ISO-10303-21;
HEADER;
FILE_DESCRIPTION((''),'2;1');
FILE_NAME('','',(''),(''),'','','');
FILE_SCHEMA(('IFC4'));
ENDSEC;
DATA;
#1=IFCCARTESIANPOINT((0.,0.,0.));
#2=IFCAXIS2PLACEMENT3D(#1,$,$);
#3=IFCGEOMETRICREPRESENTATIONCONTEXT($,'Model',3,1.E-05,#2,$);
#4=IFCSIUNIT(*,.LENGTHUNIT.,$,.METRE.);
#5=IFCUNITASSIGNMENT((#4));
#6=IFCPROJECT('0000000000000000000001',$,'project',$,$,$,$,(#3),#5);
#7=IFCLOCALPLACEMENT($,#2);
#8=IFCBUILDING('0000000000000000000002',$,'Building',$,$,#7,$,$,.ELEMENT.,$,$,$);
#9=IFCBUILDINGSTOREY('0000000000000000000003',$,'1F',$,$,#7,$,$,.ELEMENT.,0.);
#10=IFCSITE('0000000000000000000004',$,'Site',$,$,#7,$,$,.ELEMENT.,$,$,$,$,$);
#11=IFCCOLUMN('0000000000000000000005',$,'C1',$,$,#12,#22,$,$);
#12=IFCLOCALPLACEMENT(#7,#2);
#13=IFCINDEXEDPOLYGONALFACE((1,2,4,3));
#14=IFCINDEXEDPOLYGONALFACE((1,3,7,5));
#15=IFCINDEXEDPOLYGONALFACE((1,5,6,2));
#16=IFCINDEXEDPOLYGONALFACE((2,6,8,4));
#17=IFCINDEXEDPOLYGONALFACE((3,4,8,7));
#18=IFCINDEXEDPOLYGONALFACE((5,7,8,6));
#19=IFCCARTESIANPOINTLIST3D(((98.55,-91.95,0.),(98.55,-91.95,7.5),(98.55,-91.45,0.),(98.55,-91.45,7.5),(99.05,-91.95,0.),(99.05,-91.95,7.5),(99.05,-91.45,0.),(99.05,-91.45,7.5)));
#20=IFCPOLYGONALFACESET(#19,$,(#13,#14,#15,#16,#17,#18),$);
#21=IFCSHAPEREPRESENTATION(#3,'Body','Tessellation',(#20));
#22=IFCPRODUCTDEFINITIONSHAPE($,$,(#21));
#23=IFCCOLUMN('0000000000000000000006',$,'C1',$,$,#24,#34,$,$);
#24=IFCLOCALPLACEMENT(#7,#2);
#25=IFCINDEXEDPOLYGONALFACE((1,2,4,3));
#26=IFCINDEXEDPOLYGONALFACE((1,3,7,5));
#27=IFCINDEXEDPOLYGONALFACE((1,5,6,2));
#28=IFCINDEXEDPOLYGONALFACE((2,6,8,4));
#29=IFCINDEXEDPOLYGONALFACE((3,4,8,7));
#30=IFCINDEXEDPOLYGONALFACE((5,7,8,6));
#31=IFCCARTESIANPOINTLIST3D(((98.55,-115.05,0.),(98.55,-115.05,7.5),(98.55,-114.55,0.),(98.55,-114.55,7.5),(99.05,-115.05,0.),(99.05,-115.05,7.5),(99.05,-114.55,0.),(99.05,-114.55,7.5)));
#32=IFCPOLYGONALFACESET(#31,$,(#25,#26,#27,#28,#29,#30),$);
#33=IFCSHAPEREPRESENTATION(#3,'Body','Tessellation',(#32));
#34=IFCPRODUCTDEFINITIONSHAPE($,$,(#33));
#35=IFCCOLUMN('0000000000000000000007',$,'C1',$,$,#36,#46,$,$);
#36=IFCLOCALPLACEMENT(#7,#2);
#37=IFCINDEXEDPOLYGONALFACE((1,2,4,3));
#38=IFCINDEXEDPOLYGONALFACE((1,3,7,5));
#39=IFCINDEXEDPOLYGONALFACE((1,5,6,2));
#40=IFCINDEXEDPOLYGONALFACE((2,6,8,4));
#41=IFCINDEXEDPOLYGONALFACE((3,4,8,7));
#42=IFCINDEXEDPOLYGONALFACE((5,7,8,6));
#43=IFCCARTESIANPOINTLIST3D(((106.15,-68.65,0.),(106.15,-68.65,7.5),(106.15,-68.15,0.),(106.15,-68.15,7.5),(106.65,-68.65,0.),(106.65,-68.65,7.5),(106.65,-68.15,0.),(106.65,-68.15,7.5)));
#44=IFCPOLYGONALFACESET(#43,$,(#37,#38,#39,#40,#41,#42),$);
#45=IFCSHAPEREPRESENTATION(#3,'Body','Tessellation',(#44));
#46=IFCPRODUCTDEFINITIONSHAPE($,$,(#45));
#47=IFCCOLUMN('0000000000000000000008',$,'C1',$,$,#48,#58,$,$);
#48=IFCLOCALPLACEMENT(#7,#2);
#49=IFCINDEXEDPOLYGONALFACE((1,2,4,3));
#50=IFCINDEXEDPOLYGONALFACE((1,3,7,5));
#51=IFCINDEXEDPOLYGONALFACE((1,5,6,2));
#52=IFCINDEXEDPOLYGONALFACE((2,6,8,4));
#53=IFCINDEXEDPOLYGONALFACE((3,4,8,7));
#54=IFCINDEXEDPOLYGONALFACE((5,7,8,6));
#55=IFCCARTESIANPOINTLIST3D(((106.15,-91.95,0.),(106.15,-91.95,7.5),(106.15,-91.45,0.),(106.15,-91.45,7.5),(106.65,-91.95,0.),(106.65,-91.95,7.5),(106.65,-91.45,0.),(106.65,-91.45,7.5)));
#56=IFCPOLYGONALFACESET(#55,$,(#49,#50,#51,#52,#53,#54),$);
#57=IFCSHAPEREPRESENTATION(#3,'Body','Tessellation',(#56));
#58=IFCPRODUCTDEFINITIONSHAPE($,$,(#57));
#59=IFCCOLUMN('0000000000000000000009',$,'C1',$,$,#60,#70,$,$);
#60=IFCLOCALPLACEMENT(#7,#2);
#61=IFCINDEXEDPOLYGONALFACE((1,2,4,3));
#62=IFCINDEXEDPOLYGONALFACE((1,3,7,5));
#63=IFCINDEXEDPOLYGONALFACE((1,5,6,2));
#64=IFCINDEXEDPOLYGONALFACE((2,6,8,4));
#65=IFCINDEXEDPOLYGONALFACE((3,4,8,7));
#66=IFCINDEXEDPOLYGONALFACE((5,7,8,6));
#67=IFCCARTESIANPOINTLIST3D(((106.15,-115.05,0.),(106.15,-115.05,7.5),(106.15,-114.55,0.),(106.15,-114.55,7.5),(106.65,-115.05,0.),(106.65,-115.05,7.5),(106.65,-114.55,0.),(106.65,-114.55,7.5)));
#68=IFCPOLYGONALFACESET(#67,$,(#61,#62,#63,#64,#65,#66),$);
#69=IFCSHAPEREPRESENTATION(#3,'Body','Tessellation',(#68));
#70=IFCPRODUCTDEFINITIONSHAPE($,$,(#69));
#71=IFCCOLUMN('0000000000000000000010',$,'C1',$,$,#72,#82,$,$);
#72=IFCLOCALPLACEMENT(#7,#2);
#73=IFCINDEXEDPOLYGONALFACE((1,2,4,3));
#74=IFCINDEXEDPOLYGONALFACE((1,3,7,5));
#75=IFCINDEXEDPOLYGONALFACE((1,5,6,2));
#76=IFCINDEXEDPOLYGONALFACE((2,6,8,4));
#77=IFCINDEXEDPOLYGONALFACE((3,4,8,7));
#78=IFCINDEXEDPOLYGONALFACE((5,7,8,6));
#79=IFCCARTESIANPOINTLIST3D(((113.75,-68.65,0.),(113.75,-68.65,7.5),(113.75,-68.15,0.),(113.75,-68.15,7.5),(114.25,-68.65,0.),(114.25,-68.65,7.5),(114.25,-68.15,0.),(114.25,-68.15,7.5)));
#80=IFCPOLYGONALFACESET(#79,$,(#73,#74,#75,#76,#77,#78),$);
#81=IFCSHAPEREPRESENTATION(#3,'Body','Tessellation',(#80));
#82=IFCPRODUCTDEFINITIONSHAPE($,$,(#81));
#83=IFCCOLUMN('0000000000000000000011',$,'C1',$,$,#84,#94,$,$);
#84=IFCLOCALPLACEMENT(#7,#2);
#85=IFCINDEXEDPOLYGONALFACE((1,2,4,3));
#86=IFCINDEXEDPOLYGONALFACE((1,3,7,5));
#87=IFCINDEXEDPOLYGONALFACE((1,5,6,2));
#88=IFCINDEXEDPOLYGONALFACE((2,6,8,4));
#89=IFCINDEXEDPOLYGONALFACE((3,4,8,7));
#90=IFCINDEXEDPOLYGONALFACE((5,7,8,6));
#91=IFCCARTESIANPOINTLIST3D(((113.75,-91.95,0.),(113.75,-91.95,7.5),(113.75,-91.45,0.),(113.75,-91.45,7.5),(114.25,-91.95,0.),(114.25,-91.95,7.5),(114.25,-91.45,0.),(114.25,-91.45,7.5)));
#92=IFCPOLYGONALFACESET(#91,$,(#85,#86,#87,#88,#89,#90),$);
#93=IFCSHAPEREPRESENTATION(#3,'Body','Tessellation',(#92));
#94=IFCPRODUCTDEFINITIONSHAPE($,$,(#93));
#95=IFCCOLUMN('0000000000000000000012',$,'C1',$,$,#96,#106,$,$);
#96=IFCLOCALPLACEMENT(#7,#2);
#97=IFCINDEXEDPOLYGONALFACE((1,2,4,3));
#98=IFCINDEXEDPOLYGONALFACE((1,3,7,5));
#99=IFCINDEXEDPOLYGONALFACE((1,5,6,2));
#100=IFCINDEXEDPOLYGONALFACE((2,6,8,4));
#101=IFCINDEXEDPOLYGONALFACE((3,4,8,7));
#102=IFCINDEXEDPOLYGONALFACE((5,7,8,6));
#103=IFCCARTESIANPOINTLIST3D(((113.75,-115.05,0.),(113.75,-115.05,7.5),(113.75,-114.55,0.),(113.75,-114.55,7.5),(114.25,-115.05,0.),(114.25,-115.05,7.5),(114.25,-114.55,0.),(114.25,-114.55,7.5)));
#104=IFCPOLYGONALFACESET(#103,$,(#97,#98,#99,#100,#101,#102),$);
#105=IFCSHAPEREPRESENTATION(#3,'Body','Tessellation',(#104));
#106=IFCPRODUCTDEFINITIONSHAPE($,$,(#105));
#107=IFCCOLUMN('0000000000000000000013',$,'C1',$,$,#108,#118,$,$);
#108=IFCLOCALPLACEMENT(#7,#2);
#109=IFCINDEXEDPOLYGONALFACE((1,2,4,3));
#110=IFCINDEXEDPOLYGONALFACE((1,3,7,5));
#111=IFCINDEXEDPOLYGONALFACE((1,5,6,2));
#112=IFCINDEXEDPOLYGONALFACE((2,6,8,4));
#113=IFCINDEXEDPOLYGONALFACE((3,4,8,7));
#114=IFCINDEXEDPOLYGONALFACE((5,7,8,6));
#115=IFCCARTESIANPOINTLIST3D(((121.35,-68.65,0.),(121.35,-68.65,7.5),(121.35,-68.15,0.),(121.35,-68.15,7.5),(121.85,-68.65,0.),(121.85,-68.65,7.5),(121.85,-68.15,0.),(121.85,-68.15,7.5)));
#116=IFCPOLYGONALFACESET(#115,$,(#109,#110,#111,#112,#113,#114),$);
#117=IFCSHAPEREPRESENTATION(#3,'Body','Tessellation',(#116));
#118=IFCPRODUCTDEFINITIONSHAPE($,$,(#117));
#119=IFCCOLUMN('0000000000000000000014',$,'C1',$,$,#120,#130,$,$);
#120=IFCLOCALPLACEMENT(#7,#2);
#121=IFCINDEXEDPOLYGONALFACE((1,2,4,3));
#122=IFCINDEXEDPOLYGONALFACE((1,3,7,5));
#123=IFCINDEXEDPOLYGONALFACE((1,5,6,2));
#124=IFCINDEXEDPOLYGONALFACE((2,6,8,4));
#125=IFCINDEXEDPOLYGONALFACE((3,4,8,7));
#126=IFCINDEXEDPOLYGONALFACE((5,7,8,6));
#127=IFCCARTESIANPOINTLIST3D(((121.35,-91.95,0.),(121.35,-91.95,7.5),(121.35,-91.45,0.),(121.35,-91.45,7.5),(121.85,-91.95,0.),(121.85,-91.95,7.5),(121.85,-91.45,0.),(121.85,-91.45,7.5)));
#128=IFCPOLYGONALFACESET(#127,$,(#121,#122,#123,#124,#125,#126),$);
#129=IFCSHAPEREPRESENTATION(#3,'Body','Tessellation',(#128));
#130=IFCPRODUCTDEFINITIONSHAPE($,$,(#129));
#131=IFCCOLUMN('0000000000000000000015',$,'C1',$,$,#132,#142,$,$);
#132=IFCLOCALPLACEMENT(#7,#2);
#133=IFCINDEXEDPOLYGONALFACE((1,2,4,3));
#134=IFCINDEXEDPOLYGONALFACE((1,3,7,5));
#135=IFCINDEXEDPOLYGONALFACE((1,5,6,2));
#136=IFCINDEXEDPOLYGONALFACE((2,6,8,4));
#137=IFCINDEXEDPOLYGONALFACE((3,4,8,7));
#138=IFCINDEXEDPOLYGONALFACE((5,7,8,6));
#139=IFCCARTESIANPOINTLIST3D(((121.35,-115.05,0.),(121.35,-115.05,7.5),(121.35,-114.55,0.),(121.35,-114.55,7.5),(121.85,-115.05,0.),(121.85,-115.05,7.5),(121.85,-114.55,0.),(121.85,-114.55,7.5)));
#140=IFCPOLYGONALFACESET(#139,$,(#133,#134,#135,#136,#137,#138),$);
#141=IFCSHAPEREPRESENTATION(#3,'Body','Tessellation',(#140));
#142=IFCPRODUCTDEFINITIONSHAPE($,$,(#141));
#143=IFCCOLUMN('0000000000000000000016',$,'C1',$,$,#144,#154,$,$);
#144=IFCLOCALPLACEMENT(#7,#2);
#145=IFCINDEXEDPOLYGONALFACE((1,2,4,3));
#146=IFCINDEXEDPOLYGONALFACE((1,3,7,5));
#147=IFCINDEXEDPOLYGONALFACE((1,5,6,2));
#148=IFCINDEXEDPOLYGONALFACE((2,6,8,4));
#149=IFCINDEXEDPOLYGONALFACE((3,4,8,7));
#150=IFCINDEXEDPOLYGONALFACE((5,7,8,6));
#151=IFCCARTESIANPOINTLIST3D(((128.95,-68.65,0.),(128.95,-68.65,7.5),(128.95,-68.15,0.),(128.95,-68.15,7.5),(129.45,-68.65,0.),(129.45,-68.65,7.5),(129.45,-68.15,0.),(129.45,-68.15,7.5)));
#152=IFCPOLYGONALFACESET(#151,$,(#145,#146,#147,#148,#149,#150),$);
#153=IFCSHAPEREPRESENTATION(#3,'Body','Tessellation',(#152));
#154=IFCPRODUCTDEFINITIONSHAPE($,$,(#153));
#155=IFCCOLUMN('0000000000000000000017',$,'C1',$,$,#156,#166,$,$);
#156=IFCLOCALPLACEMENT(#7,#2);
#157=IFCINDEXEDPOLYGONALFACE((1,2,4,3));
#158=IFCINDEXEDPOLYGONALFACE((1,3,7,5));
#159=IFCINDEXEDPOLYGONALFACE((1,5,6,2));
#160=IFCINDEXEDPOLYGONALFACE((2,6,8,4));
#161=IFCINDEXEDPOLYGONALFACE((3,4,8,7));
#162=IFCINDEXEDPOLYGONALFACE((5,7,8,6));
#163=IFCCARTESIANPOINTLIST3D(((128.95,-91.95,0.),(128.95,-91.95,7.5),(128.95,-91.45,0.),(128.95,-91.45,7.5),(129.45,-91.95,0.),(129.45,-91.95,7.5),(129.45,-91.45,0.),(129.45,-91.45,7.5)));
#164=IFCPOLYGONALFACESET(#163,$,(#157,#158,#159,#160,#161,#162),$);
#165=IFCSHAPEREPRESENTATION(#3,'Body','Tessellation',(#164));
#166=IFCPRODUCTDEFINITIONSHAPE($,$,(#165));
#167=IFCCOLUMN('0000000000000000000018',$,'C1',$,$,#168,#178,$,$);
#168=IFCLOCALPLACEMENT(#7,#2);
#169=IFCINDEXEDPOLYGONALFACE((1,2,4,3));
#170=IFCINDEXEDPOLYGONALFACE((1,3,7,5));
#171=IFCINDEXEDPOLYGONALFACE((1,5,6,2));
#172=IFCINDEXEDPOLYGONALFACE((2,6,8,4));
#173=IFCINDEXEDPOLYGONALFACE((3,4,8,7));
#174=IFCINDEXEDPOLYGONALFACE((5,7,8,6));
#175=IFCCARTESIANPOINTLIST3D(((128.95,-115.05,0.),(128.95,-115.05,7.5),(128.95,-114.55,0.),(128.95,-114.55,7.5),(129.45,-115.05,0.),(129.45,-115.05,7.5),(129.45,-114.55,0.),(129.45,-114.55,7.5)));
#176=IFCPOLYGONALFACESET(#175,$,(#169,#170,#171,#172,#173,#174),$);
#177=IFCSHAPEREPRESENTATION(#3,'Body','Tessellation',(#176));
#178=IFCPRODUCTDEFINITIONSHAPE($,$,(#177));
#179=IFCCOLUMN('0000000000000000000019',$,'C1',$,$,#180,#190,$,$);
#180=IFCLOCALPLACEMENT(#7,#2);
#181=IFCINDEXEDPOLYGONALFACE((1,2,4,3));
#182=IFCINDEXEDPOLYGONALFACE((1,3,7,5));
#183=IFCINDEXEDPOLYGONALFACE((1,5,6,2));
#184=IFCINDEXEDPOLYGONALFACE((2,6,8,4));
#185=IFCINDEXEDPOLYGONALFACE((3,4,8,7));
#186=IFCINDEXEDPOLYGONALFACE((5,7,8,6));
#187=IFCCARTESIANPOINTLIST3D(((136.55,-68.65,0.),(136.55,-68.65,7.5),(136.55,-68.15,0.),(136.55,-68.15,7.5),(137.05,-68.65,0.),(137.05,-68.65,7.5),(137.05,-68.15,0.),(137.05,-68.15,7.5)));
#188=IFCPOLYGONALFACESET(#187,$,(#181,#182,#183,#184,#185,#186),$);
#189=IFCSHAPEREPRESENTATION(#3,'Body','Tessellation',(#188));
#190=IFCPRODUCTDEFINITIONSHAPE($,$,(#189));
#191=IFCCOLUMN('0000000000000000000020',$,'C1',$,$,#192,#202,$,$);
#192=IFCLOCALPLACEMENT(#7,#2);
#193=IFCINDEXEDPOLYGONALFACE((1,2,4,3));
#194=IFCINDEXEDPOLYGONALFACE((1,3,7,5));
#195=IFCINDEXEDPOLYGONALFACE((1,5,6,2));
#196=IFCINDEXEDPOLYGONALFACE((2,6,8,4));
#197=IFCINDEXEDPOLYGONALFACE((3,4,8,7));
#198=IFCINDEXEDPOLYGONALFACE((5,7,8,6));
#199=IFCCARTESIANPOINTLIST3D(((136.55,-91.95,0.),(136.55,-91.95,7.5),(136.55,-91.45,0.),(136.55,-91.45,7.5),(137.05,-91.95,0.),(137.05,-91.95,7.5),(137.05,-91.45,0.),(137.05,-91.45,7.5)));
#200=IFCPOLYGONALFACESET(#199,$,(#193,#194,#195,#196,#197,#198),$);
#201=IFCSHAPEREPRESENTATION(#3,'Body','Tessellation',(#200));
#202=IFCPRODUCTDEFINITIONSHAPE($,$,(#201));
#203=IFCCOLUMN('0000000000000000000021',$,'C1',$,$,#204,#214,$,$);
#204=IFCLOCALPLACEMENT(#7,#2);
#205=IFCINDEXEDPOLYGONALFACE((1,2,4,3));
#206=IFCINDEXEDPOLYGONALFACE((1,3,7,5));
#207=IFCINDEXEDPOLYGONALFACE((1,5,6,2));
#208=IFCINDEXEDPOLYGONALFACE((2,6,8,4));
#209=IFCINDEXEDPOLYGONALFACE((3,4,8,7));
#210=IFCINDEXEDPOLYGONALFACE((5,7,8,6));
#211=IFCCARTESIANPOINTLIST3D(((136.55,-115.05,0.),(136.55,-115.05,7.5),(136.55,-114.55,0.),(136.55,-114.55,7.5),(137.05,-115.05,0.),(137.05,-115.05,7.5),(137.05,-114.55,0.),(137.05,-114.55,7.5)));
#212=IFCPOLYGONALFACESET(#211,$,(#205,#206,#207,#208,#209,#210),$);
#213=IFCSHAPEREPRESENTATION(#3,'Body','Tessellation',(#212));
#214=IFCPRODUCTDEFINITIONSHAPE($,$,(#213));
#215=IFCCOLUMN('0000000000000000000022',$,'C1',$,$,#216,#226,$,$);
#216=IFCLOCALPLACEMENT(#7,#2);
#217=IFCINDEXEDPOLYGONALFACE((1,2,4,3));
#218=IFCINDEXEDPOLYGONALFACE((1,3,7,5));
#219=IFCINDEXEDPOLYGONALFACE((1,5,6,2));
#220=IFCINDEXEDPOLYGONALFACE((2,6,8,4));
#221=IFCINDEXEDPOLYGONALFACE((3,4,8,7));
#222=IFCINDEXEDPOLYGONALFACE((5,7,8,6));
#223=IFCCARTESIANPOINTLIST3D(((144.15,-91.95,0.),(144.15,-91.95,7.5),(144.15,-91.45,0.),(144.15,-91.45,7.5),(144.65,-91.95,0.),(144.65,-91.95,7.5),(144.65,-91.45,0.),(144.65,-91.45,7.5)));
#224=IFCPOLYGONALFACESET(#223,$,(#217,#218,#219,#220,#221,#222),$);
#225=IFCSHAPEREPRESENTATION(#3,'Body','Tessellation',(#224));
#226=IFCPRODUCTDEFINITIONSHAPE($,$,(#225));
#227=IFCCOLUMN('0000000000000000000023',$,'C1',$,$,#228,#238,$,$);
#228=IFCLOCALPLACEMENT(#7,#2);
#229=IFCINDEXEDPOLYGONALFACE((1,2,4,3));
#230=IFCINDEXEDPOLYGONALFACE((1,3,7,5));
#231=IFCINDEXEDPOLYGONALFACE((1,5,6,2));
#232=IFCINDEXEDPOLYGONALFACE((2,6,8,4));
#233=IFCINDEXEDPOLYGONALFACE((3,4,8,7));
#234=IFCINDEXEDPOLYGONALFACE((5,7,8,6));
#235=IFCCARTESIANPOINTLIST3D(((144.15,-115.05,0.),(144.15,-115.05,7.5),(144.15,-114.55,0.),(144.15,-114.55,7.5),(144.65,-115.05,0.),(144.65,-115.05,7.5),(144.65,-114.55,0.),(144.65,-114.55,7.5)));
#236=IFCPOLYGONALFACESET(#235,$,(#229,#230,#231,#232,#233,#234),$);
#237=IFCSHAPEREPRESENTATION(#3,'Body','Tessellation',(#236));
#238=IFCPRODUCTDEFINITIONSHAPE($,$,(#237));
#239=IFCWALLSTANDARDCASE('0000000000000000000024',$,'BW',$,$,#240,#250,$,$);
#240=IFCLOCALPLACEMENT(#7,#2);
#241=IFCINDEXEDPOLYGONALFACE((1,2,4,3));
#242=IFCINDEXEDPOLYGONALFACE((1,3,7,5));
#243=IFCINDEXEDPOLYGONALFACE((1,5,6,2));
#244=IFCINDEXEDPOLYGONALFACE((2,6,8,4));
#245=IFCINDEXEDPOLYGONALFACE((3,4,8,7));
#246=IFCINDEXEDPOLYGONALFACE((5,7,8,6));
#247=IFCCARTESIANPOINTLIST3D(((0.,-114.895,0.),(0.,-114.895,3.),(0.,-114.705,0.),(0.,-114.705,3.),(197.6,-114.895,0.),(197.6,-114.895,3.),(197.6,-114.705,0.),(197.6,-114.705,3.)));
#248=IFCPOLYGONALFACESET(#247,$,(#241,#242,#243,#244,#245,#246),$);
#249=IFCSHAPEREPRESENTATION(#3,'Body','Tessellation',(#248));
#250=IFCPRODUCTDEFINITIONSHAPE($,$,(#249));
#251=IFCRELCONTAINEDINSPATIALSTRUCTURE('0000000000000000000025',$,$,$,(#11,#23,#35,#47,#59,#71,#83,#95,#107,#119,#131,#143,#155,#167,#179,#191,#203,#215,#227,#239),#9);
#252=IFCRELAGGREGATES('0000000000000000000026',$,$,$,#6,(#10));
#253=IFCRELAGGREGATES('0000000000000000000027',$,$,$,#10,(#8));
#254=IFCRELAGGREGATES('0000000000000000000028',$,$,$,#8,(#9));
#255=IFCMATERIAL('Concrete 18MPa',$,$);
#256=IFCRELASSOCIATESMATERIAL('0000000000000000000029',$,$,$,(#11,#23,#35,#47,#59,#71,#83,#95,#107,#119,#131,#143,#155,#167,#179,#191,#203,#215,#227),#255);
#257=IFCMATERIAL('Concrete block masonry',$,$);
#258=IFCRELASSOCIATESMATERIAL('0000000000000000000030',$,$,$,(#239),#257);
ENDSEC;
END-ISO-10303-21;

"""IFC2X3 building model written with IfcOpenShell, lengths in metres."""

from ifc_helpers import new_model, si_unit, frame, origin, origin_2d, place, context, project, spatial, rectangle, extrude, material, element, save


model = new_model("IFC2X3")

# Units and contexts
model_context = context("Model", 3, precision=1e-05, world=origin())
ifc_project = project(units=[si_unit("LENGTHUNIT", "METRE")], contexts=[model_context])

# Site, building, storey
placement = place(None, origin())
site = spatial("IfcSite", under=ifc_project, at=placement, Name="Site", CompositionType="ELEMENT")
building = spatial("IfcBuilding", under=site, at=placement, Name="Building", CompositionType="ELEMENT")
storey = spatial("IfcBuildingStorey", under=building, at=placement, Name="1F", CompositionType="ELEMENT", Elevation=0.0)

# Columns
ifc_material_1 = material(Name="Concrete 18MPa")
for number, where, name in (
    (1, (98.8, -91.7, 0.0), "C1"),
    (2, (98.8, -114.8, 0.0), "C1"),
    (3, (106.4, -68.4, 0.0), "C1"),
    (4, (106.4, -91.7, 0.0), "C1"),
    (5, (106.4, -114.8, 0.0), "C1"),
    (6, (114.0, -68.4, 0.0), "C1"),
    (7, (114.0, -91.7, 0.0), "C1"),
    (8, (114.0, -114.8, 0.0), "C1"),
    (9, (121.6, -68.4, 0.0), "C1"),
    (10, (121.6, -91.7, 0.0), "C1"),
    (11, (121.6, -114.8, 0.0), "C1"),
    (12, (129.2, -68.4, 0.0), "C1"),
    (13, (129.2, -91.7, 0.0), "C1"),
    (14, (129.2, -114.8, 0.0), "C1"),
    (15, (136.8, -68.4, 0.0), "C1"),
    (16, (136.8, -91.7, 0.0), "C1"),
    (17, (136.8, -114.8, 0.0), "C1"),
    (18, (144.4, -91.7, 0.0), "C1"),
    (19, (144.4, -114.8, 0.0), "C1"),
):
    element("IfcColumn", number, at=place(None, frame(where)), inside=storey, material=ifc_material_1, Name=name, context=model_context, shape_type="SweptSolid", body=[
        extrude(rectangle(XDim=0.5, YDim=0.5, at=origin_2d()), origin(), (0.0, 0.0, 1.0), 7.5),
    ])

# Wall
ifc_material_2 = material(Name="Concrete block masonry")
wall_placement = place(None, frame((98.8, -114.8, 0.0)))
element("IfcWallStandardCase", 20, at=wall_placement, inside=storey, material=ifc_material_2, Name="BW", context=model_context, shape_type="SweptSolid", body=[
    extrude(rectangle(XDim=197.6, YDim=0.19, at=origin_2d()), origin(), (0.0, 0.0, 1.0), 3.0),
])

save(model, "model.ifc")
